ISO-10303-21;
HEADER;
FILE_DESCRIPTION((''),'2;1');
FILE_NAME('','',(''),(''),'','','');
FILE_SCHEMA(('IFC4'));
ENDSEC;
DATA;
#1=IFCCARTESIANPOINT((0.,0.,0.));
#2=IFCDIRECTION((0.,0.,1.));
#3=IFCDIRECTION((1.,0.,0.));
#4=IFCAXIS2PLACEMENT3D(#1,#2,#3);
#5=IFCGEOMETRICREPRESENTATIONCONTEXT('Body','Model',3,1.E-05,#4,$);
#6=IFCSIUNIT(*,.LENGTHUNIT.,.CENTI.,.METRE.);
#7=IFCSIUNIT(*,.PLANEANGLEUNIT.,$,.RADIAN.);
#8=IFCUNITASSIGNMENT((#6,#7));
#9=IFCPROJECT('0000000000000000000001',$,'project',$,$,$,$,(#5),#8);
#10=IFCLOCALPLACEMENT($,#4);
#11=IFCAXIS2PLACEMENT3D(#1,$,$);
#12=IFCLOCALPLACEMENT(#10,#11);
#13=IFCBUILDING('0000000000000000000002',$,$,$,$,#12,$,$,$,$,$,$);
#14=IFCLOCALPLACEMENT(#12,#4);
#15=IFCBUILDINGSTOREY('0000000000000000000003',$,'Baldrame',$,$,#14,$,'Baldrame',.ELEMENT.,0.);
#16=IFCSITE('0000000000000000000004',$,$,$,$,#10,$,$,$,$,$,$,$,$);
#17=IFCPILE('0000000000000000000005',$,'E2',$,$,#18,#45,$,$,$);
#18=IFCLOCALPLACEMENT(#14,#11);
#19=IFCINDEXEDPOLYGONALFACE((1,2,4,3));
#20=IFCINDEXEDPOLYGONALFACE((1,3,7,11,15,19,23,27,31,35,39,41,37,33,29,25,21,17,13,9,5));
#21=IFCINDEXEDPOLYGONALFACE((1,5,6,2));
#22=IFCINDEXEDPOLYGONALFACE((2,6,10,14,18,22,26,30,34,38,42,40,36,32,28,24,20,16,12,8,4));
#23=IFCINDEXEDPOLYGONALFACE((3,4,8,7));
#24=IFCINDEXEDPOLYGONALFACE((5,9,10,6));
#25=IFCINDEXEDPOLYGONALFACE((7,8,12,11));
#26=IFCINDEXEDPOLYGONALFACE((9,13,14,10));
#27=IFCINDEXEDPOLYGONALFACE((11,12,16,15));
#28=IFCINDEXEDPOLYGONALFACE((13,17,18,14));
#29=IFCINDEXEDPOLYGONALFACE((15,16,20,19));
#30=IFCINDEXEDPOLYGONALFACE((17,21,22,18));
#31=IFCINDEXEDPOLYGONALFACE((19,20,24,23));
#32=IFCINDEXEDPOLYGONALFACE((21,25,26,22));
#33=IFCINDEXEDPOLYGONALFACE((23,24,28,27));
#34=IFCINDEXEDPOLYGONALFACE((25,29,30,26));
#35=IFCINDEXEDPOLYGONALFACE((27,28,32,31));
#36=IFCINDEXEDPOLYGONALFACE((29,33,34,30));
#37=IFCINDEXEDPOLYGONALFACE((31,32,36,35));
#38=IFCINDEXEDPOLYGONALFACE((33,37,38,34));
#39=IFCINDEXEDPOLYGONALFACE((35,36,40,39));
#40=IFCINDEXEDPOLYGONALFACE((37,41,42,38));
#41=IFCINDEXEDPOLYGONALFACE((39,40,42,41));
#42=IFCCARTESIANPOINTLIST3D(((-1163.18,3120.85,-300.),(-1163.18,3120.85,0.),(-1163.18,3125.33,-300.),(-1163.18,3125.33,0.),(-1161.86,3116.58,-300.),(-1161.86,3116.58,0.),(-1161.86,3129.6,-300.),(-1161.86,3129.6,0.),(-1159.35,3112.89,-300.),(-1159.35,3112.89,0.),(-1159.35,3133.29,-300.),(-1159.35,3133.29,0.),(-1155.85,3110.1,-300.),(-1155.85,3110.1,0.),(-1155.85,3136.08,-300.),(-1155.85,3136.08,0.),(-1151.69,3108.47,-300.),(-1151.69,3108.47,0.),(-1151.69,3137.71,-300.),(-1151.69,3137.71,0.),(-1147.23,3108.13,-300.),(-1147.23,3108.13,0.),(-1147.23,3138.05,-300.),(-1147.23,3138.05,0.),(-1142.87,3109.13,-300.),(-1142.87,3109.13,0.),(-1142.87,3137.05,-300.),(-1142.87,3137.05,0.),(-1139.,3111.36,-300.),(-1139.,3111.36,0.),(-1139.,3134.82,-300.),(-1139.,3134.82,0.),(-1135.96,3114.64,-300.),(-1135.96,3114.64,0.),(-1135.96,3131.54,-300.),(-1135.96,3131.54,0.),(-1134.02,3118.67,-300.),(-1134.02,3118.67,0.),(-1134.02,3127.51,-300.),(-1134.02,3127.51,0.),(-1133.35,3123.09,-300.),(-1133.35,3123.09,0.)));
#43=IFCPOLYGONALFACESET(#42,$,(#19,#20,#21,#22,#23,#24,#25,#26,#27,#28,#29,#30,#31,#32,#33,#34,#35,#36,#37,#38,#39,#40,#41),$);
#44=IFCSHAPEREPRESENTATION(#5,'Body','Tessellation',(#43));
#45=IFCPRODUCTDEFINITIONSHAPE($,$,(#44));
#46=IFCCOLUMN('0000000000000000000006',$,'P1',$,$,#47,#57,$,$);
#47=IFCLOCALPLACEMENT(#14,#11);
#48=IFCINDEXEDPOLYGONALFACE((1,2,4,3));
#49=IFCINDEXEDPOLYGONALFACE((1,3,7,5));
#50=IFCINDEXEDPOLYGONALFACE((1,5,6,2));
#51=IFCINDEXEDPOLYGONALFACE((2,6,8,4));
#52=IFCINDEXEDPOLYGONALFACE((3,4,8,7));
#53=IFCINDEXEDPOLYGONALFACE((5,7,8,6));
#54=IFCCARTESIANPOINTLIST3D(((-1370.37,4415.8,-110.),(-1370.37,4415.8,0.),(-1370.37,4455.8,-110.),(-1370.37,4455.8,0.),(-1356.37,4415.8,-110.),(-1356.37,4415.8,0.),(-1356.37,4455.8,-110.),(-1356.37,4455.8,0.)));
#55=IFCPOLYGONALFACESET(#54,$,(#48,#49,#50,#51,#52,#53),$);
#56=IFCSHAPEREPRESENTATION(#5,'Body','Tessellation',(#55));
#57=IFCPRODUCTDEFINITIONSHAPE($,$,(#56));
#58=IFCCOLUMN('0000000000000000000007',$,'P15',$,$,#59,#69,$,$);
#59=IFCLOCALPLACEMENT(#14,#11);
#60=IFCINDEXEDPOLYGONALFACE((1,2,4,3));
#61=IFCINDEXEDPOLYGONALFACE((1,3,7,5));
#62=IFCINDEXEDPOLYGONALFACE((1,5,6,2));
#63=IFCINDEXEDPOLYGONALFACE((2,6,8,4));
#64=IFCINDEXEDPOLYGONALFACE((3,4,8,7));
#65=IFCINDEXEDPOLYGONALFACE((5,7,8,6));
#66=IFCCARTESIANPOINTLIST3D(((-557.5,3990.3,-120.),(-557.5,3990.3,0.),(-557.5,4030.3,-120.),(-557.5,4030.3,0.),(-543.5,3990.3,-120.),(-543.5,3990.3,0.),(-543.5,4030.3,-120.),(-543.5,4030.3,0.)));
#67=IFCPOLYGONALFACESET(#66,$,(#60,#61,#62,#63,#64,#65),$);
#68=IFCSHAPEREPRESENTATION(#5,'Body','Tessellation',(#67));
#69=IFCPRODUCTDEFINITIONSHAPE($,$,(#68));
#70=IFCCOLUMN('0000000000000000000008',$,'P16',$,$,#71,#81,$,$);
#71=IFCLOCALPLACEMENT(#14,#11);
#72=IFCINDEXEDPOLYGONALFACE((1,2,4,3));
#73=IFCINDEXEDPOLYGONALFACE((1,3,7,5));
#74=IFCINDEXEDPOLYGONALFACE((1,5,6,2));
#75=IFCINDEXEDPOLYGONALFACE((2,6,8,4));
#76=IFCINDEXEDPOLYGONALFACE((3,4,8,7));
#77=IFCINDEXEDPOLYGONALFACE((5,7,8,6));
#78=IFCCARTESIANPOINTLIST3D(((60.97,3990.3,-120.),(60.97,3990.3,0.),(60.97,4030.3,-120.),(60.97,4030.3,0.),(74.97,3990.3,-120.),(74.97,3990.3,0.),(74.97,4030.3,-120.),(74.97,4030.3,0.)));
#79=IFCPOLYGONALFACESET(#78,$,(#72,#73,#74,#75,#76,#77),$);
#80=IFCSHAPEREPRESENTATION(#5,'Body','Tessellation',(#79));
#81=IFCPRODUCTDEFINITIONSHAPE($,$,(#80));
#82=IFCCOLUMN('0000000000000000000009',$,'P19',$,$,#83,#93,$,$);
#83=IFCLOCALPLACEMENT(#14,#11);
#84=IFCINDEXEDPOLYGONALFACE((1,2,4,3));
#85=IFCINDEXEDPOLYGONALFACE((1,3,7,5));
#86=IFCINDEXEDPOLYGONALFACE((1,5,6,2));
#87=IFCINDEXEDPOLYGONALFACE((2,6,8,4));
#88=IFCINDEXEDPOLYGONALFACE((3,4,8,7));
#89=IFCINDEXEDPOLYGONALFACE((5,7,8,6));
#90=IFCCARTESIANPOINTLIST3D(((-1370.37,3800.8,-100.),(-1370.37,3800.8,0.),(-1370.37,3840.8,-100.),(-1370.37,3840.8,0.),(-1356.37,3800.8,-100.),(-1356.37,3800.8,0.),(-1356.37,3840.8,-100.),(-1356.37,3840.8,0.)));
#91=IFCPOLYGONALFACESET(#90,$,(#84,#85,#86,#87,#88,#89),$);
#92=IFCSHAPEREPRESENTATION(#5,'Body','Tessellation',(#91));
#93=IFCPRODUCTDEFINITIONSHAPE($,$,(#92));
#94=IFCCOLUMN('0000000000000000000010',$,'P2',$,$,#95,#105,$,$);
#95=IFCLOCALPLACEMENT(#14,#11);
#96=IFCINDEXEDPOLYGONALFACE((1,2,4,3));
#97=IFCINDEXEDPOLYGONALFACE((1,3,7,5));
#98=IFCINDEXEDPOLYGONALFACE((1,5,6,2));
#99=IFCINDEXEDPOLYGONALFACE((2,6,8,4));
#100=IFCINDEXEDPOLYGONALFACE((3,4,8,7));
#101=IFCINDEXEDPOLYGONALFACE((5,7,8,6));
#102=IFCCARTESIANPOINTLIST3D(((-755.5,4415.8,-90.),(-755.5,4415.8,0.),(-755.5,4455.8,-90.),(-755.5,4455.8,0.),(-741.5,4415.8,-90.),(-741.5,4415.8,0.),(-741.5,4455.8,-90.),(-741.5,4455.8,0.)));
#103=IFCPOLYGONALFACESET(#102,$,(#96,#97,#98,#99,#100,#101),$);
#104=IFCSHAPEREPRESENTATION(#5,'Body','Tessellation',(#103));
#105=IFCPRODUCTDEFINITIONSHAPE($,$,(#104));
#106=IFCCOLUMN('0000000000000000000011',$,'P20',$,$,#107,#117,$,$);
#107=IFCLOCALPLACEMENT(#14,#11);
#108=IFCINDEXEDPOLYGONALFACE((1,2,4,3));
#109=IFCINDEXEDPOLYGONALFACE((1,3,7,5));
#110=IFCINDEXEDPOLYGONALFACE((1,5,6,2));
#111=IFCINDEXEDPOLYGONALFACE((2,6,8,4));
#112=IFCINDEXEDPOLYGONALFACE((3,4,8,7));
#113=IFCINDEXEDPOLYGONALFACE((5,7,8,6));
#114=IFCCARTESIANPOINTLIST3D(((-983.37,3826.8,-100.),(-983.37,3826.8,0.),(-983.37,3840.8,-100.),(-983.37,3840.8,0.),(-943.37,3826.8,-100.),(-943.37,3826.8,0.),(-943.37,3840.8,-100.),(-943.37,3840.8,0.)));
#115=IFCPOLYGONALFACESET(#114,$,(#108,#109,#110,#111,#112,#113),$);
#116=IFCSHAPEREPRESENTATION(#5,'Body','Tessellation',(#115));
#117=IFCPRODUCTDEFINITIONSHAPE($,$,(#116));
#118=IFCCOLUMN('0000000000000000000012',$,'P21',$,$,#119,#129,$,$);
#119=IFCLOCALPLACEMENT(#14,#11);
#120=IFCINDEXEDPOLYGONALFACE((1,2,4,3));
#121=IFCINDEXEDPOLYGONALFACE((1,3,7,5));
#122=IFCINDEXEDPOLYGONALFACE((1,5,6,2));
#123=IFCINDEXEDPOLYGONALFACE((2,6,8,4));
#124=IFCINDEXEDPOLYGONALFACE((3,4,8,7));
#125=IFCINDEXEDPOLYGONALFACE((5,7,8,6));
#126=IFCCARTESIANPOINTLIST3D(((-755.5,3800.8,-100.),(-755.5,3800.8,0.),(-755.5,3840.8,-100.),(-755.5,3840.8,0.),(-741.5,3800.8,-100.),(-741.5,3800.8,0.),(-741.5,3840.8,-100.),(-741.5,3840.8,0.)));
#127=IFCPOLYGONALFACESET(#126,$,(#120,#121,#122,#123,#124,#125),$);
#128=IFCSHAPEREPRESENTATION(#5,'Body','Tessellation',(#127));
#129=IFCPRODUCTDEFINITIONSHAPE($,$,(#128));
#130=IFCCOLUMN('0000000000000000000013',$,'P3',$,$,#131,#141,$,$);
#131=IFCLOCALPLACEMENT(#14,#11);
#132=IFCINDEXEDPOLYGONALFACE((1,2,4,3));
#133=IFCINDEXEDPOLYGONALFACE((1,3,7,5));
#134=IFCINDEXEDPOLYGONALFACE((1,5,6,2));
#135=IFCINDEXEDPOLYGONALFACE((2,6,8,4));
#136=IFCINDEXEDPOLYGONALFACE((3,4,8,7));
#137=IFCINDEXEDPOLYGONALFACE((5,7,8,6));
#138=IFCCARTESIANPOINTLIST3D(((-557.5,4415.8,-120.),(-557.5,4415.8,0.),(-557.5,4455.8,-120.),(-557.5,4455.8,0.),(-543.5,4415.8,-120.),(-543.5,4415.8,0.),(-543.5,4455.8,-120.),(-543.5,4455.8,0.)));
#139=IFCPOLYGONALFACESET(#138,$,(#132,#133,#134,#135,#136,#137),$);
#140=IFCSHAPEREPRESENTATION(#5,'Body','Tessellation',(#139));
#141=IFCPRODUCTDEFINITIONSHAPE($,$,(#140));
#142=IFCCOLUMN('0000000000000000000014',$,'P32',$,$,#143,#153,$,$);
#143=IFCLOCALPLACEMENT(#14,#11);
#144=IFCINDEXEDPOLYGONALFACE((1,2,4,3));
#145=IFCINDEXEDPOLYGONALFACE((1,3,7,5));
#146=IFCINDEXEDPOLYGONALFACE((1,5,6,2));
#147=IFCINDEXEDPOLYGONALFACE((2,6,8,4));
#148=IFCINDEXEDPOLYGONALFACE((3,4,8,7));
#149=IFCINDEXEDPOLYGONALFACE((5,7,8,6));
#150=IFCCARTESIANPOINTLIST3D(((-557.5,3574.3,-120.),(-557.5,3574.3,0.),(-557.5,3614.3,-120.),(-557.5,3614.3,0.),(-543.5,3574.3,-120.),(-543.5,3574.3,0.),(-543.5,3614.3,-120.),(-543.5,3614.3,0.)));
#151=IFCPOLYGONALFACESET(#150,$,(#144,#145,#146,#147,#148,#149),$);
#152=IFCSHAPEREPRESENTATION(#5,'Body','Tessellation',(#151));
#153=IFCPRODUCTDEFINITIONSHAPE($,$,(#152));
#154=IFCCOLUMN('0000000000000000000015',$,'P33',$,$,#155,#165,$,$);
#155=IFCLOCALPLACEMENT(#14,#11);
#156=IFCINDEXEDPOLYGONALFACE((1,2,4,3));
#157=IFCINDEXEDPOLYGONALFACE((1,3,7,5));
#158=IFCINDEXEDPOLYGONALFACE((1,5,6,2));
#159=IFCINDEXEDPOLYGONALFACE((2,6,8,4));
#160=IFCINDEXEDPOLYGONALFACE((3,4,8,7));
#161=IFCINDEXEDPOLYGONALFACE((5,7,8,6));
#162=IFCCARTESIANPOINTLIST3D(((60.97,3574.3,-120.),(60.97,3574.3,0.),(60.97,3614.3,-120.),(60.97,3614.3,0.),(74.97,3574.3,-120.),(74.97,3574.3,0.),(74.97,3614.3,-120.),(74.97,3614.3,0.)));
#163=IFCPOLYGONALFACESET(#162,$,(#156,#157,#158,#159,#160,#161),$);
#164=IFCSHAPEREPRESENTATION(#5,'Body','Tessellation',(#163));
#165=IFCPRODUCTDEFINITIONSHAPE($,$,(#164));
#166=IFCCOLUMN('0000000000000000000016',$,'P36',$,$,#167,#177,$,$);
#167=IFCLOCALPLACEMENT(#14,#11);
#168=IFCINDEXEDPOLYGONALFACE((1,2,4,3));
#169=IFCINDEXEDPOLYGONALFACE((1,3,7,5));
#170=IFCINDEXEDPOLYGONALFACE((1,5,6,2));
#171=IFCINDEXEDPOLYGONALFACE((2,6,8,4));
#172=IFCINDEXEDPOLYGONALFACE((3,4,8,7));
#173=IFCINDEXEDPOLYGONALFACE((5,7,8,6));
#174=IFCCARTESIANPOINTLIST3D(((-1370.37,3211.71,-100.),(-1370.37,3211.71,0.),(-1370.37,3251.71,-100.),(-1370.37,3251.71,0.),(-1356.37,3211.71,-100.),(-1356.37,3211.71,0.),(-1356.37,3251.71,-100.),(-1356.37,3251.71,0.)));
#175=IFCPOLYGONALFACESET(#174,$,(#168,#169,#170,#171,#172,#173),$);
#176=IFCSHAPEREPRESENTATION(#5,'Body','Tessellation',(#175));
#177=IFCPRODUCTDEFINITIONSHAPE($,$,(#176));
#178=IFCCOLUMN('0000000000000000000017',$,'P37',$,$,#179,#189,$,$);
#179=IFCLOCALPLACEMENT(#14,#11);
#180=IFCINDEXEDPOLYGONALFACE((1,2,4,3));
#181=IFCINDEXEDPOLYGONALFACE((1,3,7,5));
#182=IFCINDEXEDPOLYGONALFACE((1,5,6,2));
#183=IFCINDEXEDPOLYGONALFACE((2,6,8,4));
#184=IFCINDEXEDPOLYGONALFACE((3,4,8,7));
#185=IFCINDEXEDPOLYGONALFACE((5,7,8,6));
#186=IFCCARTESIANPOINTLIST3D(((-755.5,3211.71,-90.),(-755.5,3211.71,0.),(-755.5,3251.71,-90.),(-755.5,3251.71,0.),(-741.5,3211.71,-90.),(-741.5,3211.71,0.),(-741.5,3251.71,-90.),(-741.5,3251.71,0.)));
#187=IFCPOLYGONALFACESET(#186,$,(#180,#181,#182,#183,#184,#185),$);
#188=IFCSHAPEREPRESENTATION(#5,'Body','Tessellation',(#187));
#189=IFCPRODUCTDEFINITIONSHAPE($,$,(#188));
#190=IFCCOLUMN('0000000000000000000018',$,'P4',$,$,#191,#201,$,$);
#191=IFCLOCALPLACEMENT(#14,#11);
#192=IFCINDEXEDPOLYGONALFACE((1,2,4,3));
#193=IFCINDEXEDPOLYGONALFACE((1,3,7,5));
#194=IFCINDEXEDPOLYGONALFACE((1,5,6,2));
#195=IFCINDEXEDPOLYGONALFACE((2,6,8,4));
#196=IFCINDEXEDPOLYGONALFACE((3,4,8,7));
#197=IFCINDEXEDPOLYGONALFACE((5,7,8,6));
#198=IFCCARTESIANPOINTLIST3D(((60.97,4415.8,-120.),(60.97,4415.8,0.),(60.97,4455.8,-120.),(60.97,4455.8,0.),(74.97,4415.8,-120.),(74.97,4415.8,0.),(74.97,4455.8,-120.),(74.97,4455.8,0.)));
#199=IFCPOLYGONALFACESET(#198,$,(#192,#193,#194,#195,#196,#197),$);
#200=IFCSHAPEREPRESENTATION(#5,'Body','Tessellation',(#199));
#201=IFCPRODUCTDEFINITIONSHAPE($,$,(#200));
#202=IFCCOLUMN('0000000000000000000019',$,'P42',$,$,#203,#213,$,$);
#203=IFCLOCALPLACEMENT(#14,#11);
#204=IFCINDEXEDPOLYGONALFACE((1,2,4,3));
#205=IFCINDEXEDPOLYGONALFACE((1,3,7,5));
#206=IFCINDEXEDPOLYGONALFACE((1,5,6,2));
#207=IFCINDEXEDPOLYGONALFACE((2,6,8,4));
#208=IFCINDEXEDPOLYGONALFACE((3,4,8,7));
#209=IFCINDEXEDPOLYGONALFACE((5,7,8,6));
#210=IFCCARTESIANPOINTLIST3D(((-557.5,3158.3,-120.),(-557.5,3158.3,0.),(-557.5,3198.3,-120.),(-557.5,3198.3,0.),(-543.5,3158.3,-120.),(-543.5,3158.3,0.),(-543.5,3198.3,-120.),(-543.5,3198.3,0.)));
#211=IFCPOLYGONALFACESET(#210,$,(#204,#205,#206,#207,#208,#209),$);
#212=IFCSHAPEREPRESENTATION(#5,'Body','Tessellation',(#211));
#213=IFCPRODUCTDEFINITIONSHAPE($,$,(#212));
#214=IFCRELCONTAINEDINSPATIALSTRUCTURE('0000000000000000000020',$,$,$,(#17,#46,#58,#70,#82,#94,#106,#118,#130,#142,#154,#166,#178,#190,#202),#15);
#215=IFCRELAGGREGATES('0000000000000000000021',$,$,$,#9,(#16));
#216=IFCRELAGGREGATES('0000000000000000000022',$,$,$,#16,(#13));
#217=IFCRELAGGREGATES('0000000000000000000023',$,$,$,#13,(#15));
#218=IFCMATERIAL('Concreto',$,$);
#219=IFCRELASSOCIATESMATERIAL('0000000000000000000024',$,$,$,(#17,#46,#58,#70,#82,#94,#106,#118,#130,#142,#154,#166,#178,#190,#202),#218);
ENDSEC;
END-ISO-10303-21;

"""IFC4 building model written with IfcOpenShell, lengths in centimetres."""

from ifc_helpers import new_model, si_unit, frame, origin, origin_with_axes, origin_2d_with_axis, place, context, project, spatial, rectangle, circle, extrude, material, element, save


model = new_model("IFC4")

# Units and contexts
model_context = context("Model", 3, precision=1e-05, world=origin_with_axes(), identifier="Body")
ifc_project = project(units=[si_unit("LENGTHUNIT", "METRE", prefix="CENTI"), si_unit("PLANEANGLEUNIT", "RADIAN")], contexts=[model_context])

# Site, building, storey
site_placement = place(None, origin_with_axes())
site = spatial("IfcSite", under=ifc_project, at=site_placement)
building_placement = place(site_placement, origin())
building = spatial("IfcBuilding", under=site, at=building_placement)
storey_placement = place(building_placement, origin_with_axes())
storey = spatial("IfcBuildingStorey", under=building, at=storey_placement, Name="Baldrame", LongName="Baldrame", CompositionType="ELEMENT", Elevation=0.0)

# Pile
ifc_material = material(Name="Concreto")
pile_placement = place(storey_placement, frame((-1148.35, 3123.09, 0.0), z_axis=(0.0, 0.0, 1.0), x_axis=(1.0, 0.0, 0.0)))
element("IfcPile", 1, at=pile_placement, inside=storey, material=ifc_material, Name="E2", context=model_context, shape_type="SolidModel", body=[
    extrude(circle(Radius=15.0, at=origin_2d_with_axis()), frame((0.0, 0.0, -300.0), z_axis=(0.0, 0.0, 1.0), x_axis=(1.0, 0.0, 0.0)), (0.0, 0.0, 1.0), 300.0),
])

# Columns
column_1_placement = place(storey_placement, frame((-1363.37, 4435.8, 0.0), z_axis=(0.0, 0.0, 1.0), x_axis=(1.0, 0.0, 0.0)))
element("IfcColumn", 2, at=column_1_placement, inside=storey, material=ifc_material, Name="P1", context=model_context, shape_type="SolidModel", body=[
    extrude(rectangle(XDim=14.0, YDim=40.0, at=origin_2d_with_axis()), frame((0.0, 0.0, -110.0), z_axis=(0.0, 0.0, 1.0), x_axis=(1.0, 0.0, 0.0)), (0.0, 0.0, 1.0), 110.0),
])
for number, where, z_axis, x_axis, name in (
    (3, (-550.5, 4010.3, 0.0), (0.0, 0.0, 1.0), (1.0, 0.0, 0.0), "P15"),
    (4, (67.97, 4010.3, 0.0), (0.0, 0.0, 1.0), (1.0, 0.0, 0.0), "P16"),
):
    element("IfcColumn", number, at=place(storey_placement, frame(where, z_axis=z_axis, x_axis=x_axis)), inside=storey, material=ifc_material, Name=name, context=model_context, shape_type="SolidModel", body=[
        extrude(rectangle(XDim=14.0, YDim=40.0, at=origin_2d_with_axis()), frame((0.0, 0.0, -120.0), z_axis=(0.0, 0.0, 1.0), x_axis=(1.0, 0.0, 0.0)), (0.0, 0.0, 1.0), 120.0),
    ])
column_2_placement = place(storey_placement, frame((-1363.37, 3820.8, 0.0), z_axis=(0.0, 0.0, 1.0), x_axis=(1.0, 0.0, 0.0)))
element("IfcColumn", 5, at=column_2_placement, inside=storey, material=ifc_material, Name="P19", context=model_context, shape_type="SolidModel", body=[
    extrude(rectangle(XDim=14.0, YDim=40.0, at=origin_2d_with_axis()), frame((0.0, 0.0, -100.0), z_axis=(0.0, 0.0, 1.0), x_axis=(1.0, 0.0, 0.0)), (0.0, 0.0, 1.0), 100.0),
])
column_3_placement = place(storey_placement, frame((-748.5, 4435.8, 0.0), z_axis=(0.0, 0.0, 1.0), x_axis=(1.0, 0.0, 0.0)))
element("IfcColumn", 6, at=column_3_placement, inside=storey, material=ifc_material, Name="P2", context=model_context, shape_type="SolidModel", body=[
    extrude(rectangle(XDim=14.0, YDim=40.0, at=origin_2d_with_axis()), frame((0.0, 0.0, -90.0), z_axis=(0.0, 0.0, 1.0), x_axis=(1.0, 0.0, 0.0)), (0.0, 0.0, 1.0), 90.0),
])
column_4_placement = place(storey_placement, frame((-963.37, 3833.8, 0.0), z_axis=(0.0, 0.0, 1.0), x_axis=(1.0, 0.0, 0.0)))
element("IfcColumn", 7, at=column_4_placement, inside=storey, material=ifc_material, Name="P20", context=model_context, shape_type="SolidModel", body=[
    extrude(rectangle(XDim=14.0, YDim=40.0, at=origin_2d_with_axis()), frame((0.0, 0.0, -100.0), z_axis=(0.0, 0.0, 1.0), x_axis=(0.0, -1.0, 0.0)), (0.0, 0.0, 1.0), 100.0),
])
column_5_placement = place(storey_placement, frame((-748.5, 3820.8, 0.0), z_axis=(0.0, 0.0, 1.0), x_axis=(1.0, 0.0, 0.0)))
element("IfcColumn", 8, at=column_5_placement, inside=storey, material=ifc_material, Name="P21", context=model_context, shape_type="SolidModel", body=[
    extrude(rectangle(XDim=14.0, YDim=40.0, at=origin_2d_with_axis()), frame((0.0, 0.0, -100.0), z_axis=(0.0, 0.0, 1.0), x_axis=(1.0, 0.0, 0.0)), (0.0, 0.0, 1.0), 100.0),
])
for number, where, z_axis, x_axis, name in (
    (9, (-550.5, 4435.8, 0.0), (0.0, 0.0, 1.0), (1.0, 0.0, 0.0), "P3"),
    (10, (-550.5, 3594.3, 0.0), (0.0, 0.0, 1.0), (1.0, 0.0, 0.0), "P32"),
    (11, (67.97, 3594.3, 0.0), (0.0, 0.0, 1.0), (1.0, 0.0, 0.0), "P33"),
):
    element("IfcColumn", number, at=place(storey_placement, frame(where, z_axis=z_axis, x_axis=x_axis)), inside=storey, material=ifc_material, Name=name, context=model_context, shape_type="SolidModel", body=[
        extrude(rectangle(XDim=14.0, YDim=40.0, at=origin_2d_with_axis()), frame((0.0, 0.0, -120.0), z_axis=(0.0, 0.0, 1.0), x_axis=(1.0, 0.0, 0.0)), (0.0, 0.0, 1.0), 120.0),
    ])
column_6_placement = place(storey_placement, frame((-1363.37, 3231.71, 0.0), z_axis=(0.0, 0.0, 1.0), x_axis=(1.0, 0.0, 0.0)))
element("IfcColumn", 12, at=column_6_placement, inside=storey, material=ifc_material, Name="P36", context=model_context, shape_type="SolidModel", body=[
    extrude(rectangle(XDim=14.0, YDim=40.0, at=origin_2d_with_axis()), frame((0.0, 0.0, -100.0), z_axis=(0.0, 0.0, 1.0), x_axis=(1.0, 0.0, 0.0)), (0.0, 0.0, 1.0), 100.0),
])
column_7_placement = place(storey_placement, frame((-748.5, 3231.71, 0.0), z_axis=(0.0, 0.0, 1.0), x_axis=(1.0, 0.0, 0.0)))
element("IfcColumn", 13, at=column_7_placement, inside=storey, material=ifc_material, Name="P37", context=model_context, shape_type="SolidModel", body=[
    extrude(rectangle(XDim=14.0, YDim=40.0, at=origin_2d_with_axis()), frame((0.0, 0.0, -90.0), z_axis=(0.0, 0.0, 1.0), x_axis=(1.0, 0.0, 0.0)), (0.0, 0.0, 1.0), 90.0),
])
for number, where, z_axis, x_axis, name in (
    (14, (67.97, 4435.8, 0.0), (0.0, 0.0, 1.0), (1.0, 0.0, 0.0), "P4"),
    (15, (-550.5, 3178.3, 0.0), (0.0, 0.0, 1.0), (1.0, 0.0, 0.0), "P42"),
):
    element("IfcColumn", number, at=place(storey_placement, frame(where, z_axis=z_axis, x_axis=x_axis)), inside=storey, material=ifc_material, Name=name, context=model_context, shape_type="SolidModel", body=[
        extrude(rectangle(XDim=14.0, YDim=40.0, at=origin_2d_with_axis()), frame((0.0, 0.0, -120.0), z_axis=(0.0, 0.0, 1.0), x_axis=(1.0, 0.0, 0.0)), (0.0, 0.0, 1.0), 120.0),
    ])

save(model, "model.ifc")
